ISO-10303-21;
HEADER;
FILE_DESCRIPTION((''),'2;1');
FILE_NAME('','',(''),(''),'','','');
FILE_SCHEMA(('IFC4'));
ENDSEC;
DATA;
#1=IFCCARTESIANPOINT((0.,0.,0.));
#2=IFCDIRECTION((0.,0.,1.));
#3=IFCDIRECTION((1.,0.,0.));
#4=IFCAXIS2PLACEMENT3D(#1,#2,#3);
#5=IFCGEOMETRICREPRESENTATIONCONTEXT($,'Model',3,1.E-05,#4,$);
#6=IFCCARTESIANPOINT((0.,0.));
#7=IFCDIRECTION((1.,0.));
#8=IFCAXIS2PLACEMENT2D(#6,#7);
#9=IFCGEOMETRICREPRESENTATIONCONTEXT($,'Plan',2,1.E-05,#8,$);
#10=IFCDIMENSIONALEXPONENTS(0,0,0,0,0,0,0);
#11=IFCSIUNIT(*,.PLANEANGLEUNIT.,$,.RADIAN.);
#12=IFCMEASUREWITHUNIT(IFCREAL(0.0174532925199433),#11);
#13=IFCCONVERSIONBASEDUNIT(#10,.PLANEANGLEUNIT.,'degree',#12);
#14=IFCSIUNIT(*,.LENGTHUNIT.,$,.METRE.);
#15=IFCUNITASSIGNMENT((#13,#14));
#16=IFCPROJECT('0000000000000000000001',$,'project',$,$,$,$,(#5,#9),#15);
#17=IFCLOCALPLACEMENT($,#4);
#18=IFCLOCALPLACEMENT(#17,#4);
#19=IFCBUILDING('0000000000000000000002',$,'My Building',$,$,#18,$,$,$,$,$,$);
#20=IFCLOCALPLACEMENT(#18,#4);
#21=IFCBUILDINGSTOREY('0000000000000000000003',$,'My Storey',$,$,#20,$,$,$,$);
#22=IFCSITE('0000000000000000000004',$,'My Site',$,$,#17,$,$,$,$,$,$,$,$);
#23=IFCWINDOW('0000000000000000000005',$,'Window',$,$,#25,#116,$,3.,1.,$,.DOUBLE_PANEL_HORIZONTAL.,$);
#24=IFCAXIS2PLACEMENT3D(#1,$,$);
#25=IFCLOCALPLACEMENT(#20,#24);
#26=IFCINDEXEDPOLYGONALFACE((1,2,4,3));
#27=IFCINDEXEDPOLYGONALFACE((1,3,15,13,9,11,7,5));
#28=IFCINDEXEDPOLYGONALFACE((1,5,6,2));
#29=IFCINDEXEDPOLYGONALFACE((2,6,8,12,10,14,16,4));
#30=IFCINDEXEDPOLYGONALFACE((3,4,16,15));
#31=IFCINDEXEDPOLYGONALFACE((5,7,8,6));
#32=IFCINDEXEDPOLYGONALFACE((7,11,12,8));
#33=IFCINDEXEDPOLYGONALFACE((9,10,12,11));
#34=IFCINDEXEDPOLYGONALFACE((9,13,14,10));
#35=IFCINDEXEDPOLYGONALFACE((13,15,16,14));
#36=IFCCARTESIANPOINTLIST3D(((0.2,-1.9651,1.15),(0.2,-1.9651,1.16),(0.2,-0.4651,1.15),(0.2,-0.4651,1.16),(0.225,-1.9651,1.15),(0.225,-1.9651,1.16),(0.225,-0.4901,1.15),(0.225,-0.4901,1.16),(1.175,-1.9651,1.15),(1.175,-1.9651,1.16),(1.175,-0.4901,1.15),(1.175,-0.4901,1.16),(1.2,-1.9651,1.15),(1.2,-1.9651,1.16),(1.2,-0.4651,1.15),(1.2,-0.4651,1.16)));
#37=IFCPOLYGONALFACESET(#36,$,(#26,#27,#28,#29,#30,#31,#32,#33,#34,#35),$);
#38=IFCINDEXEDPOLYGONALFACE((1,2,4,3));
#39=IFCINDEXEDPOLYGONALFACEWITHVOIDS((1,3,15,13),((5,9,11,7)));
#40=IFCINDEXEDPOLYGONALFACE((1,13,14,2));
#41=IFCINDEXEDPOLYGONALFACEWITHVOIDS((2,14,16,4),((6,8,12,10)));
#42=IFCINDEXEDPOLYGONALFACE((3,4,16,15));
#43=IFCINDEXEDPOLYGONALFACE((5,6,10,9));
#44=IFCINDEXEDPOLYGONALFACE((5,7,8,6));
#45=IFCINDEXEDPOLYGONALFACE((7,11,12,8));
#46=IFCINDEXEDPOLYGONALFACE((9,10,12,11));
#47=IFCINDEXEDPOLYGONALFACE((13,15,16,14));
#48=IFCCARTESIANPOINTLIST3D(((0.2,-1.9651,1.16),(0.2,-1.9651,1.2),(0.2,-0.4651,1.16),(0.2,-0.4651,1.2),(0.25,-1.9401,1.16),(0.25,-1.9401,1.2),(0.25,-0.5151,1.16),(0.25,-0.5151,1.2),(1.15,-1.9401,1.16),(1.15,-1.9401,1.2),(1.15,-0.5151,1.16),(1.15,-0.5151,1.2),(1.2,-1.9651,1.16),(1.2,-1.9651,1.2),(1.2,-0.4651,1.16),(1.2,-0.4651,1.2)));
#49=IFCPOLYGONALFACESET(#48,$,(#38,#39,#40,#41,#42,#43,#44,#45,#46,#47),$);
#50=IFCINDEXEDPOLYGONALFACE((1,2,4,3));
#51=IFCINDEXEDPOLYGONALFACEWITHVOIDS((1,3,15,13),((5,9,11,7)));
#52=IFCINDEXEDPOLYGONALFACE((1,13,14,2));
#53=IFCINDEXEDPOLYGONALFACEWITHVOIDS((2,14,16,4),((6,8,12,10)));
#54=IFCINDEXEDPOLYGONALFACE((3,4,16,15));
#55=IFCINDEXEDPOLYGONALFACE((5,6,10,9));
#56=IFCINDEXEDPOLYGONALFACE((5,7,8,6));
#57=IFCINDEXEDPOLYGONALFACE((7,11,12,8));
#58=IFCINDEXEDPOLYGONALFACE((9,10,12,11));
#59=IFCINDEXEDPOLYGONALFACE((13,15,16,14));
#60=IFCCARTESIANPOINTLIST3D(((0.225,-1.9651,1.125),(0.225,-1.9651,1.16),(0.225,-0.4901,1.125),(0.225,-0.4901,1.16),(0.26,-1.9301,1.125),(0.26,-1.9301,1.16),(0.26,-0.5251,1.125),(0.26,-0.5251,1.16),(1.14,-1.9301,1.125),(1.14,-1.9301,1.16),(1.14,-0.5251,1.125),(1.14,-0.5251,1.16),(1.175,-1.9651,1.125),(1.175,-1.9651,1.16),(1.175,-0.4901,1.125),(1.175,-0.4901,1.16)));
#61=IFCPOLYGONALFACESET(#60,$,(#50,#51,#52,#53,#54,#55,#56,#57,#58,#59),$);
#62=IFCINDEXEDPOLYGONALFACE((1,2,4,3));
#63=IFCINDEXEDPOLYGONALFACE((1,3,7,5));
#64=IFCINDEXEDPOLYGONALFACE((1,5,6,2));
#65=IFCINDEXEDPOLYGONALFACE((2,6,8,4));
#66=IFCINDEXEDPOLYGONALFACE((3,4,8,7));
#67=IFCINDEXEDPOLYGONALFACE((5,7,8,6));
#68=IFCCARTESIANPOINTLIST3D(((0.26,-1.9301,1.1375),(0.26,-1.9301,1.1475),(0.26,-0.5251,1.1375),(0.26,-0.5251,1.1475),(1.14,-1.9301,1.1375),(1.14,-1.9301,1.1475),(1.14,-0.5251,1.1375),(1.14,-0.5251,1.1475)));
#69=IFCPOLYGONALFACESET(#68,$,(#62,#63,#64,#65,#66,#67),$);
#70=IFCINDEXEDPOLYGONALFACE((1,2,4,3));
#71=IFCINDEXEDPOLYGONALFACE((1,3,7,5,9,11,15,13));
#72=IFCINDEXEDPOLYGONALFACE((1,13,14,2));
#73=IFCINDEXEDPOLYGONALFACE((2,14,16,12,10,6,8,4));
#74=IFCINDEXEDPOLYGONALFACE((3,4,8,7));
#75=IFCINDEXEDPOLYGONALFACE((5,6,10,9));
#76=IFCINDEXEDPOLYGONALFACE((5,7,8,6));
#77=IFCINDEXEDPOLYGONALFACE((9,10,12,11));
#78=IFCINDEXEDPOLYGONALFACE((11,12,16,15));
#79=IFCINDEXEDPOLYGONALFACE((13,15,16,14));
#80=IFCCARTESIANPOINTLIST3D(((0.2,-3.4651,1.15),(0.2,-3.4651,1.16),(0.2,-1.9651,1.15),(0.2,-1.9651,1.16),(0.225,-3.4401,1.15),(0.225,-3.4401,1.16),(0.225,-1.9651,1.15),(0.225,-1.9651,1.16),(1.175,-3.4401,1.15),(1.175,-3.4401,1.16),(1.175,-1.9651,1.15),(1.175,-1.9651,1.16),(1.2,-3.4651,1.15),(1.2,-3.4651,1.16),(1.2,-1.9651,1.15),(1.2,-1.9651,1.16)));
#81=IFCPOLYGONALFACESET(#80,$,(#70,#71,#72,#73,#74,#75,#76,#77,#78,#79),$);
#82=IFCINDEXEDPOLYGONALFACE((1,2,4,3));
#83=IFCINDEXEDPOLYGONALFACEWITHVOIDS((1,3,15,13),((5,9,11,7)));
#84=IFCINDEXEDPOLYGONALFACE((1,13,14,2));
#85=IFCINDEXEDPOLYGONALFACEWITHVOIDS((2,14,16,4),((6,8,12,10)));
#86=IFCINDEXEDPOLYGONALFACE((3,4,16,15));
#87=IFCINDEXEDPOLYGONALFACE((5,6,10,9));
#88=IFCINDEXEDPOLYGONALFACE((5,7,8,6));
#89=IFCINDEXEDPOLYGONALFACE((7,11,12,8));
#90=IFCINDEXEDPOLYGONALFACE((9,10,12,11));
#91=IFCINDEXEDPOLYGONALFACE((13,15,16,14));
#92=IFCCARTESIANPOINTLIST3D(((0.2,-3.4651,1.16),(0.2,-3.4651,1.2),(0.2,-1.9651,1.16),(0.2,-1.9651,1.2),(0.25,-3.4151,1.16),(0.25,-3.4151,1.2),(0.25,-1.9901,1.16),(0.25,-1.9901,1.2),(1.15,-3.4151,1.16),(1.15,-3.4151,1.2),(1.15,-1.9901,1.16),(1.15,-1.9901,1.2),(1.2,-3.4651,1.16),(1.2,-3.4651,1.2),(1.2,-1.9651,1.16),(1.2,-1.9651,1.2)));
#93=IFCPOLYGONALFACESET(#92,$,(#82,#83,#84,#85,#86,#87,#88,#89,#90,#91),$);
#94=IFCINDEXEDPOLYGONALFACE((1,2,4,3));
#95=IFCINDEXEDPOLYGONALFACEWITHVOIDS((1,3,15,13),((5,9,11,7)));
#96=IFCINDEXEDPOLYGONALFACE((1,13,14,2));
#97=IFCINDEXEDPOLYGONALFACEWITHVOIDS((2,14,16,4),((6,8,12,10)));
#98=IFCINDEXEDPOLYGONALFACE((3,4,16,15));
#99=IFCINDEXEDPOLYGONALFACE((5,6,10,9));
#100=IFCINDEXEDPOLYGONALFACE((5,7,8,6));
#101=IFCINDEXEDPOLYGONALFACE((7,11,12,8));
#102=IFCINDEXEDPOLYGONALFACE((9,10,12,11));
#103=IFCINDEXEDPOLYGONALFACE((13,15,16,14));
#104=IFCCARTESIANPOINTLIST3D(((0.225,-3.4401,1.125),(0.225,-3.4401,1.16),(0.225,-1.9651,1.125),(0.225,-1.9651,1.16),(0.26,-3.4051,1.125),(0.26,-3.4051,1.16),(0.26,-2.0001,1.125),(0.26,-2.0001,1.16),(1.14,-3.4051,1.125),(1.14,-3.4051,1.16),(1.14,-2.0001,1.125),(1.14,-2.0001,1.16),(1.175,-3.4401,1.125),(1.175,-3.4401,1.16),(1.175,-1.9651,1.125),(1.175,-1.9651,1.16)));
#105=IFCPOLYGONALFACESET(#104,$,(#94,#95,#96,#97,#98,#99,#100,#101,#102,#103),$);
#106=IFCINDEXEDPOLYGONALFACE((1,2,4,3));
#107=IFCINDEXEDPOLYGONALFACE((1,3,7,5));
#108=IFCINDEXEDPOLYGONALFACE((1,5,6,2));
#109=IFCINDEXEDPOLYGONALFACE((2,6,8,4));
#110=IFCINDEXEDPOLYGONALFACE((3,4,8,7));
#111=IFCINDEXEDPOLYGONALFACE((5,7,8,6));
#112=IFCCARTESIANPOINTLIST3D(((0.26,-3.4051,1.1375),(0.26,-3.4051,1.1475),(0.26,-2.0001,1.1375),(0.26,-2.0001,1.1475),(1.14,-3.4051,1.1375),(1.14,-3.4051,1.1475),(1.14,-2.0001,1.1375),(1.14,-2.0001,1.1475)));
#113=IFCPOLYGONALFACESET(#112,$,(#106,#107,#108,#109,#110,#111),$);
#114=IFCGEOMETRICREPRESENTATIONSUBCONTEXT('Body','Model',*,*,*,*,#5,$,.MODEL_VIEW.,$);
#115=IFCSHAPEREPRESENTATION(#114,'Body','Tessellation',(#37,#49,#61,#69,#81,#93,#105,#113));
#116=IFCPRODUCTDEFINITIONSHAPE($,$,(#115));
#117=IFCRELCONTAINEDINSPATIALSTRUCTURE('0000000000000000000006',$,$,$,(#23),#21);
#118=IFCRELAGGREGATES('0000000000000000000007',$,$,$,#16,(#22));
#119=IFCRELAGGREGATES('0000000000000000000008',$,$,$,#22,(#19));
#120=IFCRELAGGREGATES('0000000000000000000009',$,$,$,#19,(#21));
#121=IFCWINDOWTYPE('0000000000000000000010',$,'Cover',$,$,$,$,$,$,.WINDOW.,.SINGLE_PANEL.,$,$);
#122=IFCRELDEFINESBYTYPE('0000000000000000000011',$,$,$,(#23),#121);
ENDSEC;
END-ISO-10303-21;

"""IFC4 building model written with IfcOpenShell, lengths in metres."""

from ifc_helpers import new_model, entity, si_unit, converted_unit, frame, origin_with_axes, origin_2d_with_axis, place, context, subcontext, project, spatial, line, indexed_curve, outline, extrude, shape, source, transform, mapped, type_object, type_shapes, element, save


model = new_model("IFC4")

# Units and contexts
model_context = context("Model", 3, precision=1e-05, world=origin_with_axes())
plan_context = context("Plan", 2, precision=1e-05, world=origin_2d_with_axis())
body_context_1 = subcontext(model_context, "Body", "Model", "MODEL_VIEW")
body_context_2 = subcontext(plan_context, "Body", "Plan", "PLAN_VIEW")
ifc_project = project(units=[converted_unit("PLANEANGLEUNIT", "degree", entity("IfcReal", 0.0174532925199433), si_unit("PLANEANGLEUNIT", "RADIAN"), dimensions=[0, 0, 0, 0, 0, 0, 0]), si_unit("LENGTHUNIT", "METRE")], contexts=[model_context, plan_context])

# Site, building, storey
site_placement = place(None, origin_with_axes())
site = spatial("IfcSite", under=ifc_project, at=site_placement, Name="My Site")
building_placement = place(site_placement, origin_with_axes())
building = spatial("IfcBuilding", under=site, at=building_placement, Name="My Building")
storey_placement = place(building_placement, origin_with_axes())
storey = spatial("IfcBuildingStorey", under=building, at=storey_placement, Name="My Storey")

# Window
window_type_1 = type_object("IfcWindowType", Name="Cover", PartitioningType="SINGLE_PANEL", PredefinedType="WINDOW")
shared_shape_1 = source(origin_with_axes(), body_context_1, "Body", "SweptSolid", [
    extrude(outline(indexed_curve([(1.0, 1.5), (1.0, 0.0), (0.0, 0.0), (0.0, 1.5), (0.025, 1.5), (0.025, 0.025), (0.975, 0.025), (0.975, 1.5)], segments=[line(1, 2, 3, 4, 5, 6, 7, 8, 1)])), frame((0.0, 0.09, 0.0), z_axis=(0.0, -1.0, 0.0), x_axis=(1.0, 0.0, 0.0)), (0.0, 0.0, -1.0), 0.01),
    extrude(outline(indexed_curve([(0.0, 0.0), (1.0, 0.0), (1.0, 1.5), (0.0, 1.5)], segments=[line(1, 2, 3, 4, 1)]), holes=[indexed_curve([(0.05, 0.05), (0.95, 0.05), (0.95, 1.475), (0.05, 1.475)], segments=[line(1, 2, 3, 4, 1)])]), frame((0.0, 0.05, 0.0), z_axis=(0.0, -1.0, 0.0), x_axis=(1.0, 0.0, 0.0)), (0.0, 0.0, -1.0), 0.04),
    extrude(outline(indexed_curve([(0.0, 0.0), (0.95, 0.0), (0.95, 1.475), (0.0, 1.475)], segments=[line(1, 2, 3, 4, 1)]), holes=[indexed_curve([(0.035, 0.035), (0.915, 0.035), (0.915, 1.44), (0.035, 1.44)], segments=[line(1, 2, 3, 4, 1)])]), frame((0.025, 0.09, 0.025), z_axis=(0.0, -1.0, 0.0), x_axis=(1.0, 0.0, 0.0)), (0.0, 0.0, -1.0), 0.035),
    extrude(outline(indexed_curve([(0.035, 0.035), (0.915, 0.035), (0.915, 1.44), (0.035, 1.44)], segments=[line(1, 2, 3, 4, 1)])), frame((0.025, 0.1025, 0.025), z_axis=(0.0, -1.0, 0.0), x_axis=(1.0, 0.0, 0.0)), (0.0, 0.0, -1.0), 0.01),
    extrude(outline(indexed_curve([(0.0, 0.0), (0.0, 1.5), (1.0, 1.5), (1.0, 0.0), (0.975, 0.0), (0.975, 1.475), (0.025, 1.475), (0.025, 0.0)], segments=[line(1, 2, 3, 4, 5, 6, 7, 8, 1)])), frame((0.0, 0.09, 1.5), z_axis=(0.0, -1.0, 0.0), x_axis=(1.0, 0.0, 0.0)), (0.0, 0.0, -1.0), 0.01),
    extrude(outline(indexed_curve([(0.0, 0.0), (1.0, 0.0), (1.0, 1.5), (0.0, 1.5)], segments=[line(1, 2, 3, 4, 1)]), holes=[indexed_curve([(0.05, 0.025), (0.95, 0.025), (0.95, 1.45), (0.05, 1.45)], segments=[line(1, 2, 3, 4, 1)])]), frame((0.0, 0.05, 1.5), z_axis=(0.0, -1.0, 0.0), x_axis=(1.0, 0.0, 0.0)), (0.0, 0.0, -1.0), 0.04),
    extrude(outline(indexed_curve([(0.0, 0.0), (0.95, 0.0), (0.95, 1.475), (0.0, 1.475)], segments=[line(1, 2, 3, 4, 1)]), holes=[indexed_curve([(0.035, 0.035), (0.915, 0.035), (0.915, 1.44), (0.035, 1.44)], segments=[line(1, 2, 3, 4, 1)])]), frame((0.025, 0.09, 1.5), z_axis=(0.0, -1.0, 0.0), x_axis=(1.0, 0.0, 0.0)), (0.0, 0.0, -1.0), 0.035),
    extrude(outline(indexed_curve([(0.035, 0.035), (0.915, 0.035), (0.915, 1.44), (0.035, 1.44)], segments=[line(1, 2, 3, 4, 1)])), frame((0.025, 0.1025, 1.5), z_axis=(0.0, -1.0, 0.0), x_axis=(1.0, 0.0, 0.0)), (0.0, 0.0, -1.0), 0.01),
])
shared_shape_2 = source(origin_with_axes(), body_context_2, "Body", "Curve2D", [
    entity("IfcIndexedPolyCurve", entity("IfcCartesianPointList2D", [[0.05, 0.05], [0.95, 0.05]])),
    entity("IfcIndexedPolyCurve", entity("IfcCartesianPointList2D", [[0.0, 0.1], [0.025, 0.1], [0.025, 0.09], [0.05, 0.09], [0.05, 0.05], [0.0, 0.05]]), [entity("IfcLineIndex", [1, 2, 3, 4, 5, 6, 1])]),
    entity("IfcIndexedPolyCurve", entity("IfcCartesianPointList2D", [[1.0, 0.1], [0.975, 0.1], [0.975, 0.09], [0.95, 0.09], [0.95, 0.05], [1.0, 0.05]]), [entity("IfcLineIndex", [1, 2, 3, 4, 5, 6, 1])]),
    entity("IfcIndexedPolyCurve", entity("IfcCartesianPointList2D", [[0.025, 0.09], [0.06, 0.09], [0.06, 0.125], [0.025, 0.125]]), [entity("IfcLineIndex", [1, 2, 3, 4, 1])]),
    entity("IfcIndexedPolyCurve", entity("IfcCartesianPointList2D", [[0.975, 0.09], [0.94, 0.09], [0.94, 0.125], [0.975, 0.125]]), [entity("IfcLineIndex", [1, 2, 3, 4, 1])]),
    entity("IfcIndexedPolyCurve", entity("IfcCartesianPointList2D", [[0.06, 0.09], [0.94, 0.09]])),
    entity("IfcIndexedPolyCurve", entity("IfcCartesianPointList2D", [[0.06, 0.125], [0.94, 0.125]])),
    entity("IfcIndexedPolyCurve", entity("IfcCartesianPointList2D", [[0.06, 0.1075], [0.94, 0.1075]])),
])
type_shapes(window_type_1, [shared_shape_1, shared_shape_2])
window_1_placement = place(storey_placement, frame((1.2, -0.4651, 1.25), z_axis=(0.0, -1.0, 0.000001), x_axis=(-1.0, 0.0, 0.0)))
element("IfcWindow", 1, at=window_1_placement, inside=storey, type_object=window_type_1, Name="Window", OverallHeight=3.0, OverallWidth=1.0, PartitioningType="DOUBLE_PANEL_HORIZONTAL", shapes=[
    shape(body_context_1, "Body", "MappedRepresentation", [mapped(shared_shape_1, transform((0.0, 0.0, 0.0), x_axis=(1.0, 0.0, 0.0), y_axis=(0.0, 1.0, 0.0), z_axis=(0.0, 0.0, 1.0), scale=1.0))]),
    shape(body_context_2, "Body", "MappedRepresentation", [mapped(shared_shape_2, transform((0.0, 0.0, 0.0), x_axis=(1.0, 0.0, 0.0), y_axis=(0.0, 1.0, 0.0), z_axis=(0.0, 0.0, 1.0), scale=1.0))]),
])

save(model, "model.ifc")
